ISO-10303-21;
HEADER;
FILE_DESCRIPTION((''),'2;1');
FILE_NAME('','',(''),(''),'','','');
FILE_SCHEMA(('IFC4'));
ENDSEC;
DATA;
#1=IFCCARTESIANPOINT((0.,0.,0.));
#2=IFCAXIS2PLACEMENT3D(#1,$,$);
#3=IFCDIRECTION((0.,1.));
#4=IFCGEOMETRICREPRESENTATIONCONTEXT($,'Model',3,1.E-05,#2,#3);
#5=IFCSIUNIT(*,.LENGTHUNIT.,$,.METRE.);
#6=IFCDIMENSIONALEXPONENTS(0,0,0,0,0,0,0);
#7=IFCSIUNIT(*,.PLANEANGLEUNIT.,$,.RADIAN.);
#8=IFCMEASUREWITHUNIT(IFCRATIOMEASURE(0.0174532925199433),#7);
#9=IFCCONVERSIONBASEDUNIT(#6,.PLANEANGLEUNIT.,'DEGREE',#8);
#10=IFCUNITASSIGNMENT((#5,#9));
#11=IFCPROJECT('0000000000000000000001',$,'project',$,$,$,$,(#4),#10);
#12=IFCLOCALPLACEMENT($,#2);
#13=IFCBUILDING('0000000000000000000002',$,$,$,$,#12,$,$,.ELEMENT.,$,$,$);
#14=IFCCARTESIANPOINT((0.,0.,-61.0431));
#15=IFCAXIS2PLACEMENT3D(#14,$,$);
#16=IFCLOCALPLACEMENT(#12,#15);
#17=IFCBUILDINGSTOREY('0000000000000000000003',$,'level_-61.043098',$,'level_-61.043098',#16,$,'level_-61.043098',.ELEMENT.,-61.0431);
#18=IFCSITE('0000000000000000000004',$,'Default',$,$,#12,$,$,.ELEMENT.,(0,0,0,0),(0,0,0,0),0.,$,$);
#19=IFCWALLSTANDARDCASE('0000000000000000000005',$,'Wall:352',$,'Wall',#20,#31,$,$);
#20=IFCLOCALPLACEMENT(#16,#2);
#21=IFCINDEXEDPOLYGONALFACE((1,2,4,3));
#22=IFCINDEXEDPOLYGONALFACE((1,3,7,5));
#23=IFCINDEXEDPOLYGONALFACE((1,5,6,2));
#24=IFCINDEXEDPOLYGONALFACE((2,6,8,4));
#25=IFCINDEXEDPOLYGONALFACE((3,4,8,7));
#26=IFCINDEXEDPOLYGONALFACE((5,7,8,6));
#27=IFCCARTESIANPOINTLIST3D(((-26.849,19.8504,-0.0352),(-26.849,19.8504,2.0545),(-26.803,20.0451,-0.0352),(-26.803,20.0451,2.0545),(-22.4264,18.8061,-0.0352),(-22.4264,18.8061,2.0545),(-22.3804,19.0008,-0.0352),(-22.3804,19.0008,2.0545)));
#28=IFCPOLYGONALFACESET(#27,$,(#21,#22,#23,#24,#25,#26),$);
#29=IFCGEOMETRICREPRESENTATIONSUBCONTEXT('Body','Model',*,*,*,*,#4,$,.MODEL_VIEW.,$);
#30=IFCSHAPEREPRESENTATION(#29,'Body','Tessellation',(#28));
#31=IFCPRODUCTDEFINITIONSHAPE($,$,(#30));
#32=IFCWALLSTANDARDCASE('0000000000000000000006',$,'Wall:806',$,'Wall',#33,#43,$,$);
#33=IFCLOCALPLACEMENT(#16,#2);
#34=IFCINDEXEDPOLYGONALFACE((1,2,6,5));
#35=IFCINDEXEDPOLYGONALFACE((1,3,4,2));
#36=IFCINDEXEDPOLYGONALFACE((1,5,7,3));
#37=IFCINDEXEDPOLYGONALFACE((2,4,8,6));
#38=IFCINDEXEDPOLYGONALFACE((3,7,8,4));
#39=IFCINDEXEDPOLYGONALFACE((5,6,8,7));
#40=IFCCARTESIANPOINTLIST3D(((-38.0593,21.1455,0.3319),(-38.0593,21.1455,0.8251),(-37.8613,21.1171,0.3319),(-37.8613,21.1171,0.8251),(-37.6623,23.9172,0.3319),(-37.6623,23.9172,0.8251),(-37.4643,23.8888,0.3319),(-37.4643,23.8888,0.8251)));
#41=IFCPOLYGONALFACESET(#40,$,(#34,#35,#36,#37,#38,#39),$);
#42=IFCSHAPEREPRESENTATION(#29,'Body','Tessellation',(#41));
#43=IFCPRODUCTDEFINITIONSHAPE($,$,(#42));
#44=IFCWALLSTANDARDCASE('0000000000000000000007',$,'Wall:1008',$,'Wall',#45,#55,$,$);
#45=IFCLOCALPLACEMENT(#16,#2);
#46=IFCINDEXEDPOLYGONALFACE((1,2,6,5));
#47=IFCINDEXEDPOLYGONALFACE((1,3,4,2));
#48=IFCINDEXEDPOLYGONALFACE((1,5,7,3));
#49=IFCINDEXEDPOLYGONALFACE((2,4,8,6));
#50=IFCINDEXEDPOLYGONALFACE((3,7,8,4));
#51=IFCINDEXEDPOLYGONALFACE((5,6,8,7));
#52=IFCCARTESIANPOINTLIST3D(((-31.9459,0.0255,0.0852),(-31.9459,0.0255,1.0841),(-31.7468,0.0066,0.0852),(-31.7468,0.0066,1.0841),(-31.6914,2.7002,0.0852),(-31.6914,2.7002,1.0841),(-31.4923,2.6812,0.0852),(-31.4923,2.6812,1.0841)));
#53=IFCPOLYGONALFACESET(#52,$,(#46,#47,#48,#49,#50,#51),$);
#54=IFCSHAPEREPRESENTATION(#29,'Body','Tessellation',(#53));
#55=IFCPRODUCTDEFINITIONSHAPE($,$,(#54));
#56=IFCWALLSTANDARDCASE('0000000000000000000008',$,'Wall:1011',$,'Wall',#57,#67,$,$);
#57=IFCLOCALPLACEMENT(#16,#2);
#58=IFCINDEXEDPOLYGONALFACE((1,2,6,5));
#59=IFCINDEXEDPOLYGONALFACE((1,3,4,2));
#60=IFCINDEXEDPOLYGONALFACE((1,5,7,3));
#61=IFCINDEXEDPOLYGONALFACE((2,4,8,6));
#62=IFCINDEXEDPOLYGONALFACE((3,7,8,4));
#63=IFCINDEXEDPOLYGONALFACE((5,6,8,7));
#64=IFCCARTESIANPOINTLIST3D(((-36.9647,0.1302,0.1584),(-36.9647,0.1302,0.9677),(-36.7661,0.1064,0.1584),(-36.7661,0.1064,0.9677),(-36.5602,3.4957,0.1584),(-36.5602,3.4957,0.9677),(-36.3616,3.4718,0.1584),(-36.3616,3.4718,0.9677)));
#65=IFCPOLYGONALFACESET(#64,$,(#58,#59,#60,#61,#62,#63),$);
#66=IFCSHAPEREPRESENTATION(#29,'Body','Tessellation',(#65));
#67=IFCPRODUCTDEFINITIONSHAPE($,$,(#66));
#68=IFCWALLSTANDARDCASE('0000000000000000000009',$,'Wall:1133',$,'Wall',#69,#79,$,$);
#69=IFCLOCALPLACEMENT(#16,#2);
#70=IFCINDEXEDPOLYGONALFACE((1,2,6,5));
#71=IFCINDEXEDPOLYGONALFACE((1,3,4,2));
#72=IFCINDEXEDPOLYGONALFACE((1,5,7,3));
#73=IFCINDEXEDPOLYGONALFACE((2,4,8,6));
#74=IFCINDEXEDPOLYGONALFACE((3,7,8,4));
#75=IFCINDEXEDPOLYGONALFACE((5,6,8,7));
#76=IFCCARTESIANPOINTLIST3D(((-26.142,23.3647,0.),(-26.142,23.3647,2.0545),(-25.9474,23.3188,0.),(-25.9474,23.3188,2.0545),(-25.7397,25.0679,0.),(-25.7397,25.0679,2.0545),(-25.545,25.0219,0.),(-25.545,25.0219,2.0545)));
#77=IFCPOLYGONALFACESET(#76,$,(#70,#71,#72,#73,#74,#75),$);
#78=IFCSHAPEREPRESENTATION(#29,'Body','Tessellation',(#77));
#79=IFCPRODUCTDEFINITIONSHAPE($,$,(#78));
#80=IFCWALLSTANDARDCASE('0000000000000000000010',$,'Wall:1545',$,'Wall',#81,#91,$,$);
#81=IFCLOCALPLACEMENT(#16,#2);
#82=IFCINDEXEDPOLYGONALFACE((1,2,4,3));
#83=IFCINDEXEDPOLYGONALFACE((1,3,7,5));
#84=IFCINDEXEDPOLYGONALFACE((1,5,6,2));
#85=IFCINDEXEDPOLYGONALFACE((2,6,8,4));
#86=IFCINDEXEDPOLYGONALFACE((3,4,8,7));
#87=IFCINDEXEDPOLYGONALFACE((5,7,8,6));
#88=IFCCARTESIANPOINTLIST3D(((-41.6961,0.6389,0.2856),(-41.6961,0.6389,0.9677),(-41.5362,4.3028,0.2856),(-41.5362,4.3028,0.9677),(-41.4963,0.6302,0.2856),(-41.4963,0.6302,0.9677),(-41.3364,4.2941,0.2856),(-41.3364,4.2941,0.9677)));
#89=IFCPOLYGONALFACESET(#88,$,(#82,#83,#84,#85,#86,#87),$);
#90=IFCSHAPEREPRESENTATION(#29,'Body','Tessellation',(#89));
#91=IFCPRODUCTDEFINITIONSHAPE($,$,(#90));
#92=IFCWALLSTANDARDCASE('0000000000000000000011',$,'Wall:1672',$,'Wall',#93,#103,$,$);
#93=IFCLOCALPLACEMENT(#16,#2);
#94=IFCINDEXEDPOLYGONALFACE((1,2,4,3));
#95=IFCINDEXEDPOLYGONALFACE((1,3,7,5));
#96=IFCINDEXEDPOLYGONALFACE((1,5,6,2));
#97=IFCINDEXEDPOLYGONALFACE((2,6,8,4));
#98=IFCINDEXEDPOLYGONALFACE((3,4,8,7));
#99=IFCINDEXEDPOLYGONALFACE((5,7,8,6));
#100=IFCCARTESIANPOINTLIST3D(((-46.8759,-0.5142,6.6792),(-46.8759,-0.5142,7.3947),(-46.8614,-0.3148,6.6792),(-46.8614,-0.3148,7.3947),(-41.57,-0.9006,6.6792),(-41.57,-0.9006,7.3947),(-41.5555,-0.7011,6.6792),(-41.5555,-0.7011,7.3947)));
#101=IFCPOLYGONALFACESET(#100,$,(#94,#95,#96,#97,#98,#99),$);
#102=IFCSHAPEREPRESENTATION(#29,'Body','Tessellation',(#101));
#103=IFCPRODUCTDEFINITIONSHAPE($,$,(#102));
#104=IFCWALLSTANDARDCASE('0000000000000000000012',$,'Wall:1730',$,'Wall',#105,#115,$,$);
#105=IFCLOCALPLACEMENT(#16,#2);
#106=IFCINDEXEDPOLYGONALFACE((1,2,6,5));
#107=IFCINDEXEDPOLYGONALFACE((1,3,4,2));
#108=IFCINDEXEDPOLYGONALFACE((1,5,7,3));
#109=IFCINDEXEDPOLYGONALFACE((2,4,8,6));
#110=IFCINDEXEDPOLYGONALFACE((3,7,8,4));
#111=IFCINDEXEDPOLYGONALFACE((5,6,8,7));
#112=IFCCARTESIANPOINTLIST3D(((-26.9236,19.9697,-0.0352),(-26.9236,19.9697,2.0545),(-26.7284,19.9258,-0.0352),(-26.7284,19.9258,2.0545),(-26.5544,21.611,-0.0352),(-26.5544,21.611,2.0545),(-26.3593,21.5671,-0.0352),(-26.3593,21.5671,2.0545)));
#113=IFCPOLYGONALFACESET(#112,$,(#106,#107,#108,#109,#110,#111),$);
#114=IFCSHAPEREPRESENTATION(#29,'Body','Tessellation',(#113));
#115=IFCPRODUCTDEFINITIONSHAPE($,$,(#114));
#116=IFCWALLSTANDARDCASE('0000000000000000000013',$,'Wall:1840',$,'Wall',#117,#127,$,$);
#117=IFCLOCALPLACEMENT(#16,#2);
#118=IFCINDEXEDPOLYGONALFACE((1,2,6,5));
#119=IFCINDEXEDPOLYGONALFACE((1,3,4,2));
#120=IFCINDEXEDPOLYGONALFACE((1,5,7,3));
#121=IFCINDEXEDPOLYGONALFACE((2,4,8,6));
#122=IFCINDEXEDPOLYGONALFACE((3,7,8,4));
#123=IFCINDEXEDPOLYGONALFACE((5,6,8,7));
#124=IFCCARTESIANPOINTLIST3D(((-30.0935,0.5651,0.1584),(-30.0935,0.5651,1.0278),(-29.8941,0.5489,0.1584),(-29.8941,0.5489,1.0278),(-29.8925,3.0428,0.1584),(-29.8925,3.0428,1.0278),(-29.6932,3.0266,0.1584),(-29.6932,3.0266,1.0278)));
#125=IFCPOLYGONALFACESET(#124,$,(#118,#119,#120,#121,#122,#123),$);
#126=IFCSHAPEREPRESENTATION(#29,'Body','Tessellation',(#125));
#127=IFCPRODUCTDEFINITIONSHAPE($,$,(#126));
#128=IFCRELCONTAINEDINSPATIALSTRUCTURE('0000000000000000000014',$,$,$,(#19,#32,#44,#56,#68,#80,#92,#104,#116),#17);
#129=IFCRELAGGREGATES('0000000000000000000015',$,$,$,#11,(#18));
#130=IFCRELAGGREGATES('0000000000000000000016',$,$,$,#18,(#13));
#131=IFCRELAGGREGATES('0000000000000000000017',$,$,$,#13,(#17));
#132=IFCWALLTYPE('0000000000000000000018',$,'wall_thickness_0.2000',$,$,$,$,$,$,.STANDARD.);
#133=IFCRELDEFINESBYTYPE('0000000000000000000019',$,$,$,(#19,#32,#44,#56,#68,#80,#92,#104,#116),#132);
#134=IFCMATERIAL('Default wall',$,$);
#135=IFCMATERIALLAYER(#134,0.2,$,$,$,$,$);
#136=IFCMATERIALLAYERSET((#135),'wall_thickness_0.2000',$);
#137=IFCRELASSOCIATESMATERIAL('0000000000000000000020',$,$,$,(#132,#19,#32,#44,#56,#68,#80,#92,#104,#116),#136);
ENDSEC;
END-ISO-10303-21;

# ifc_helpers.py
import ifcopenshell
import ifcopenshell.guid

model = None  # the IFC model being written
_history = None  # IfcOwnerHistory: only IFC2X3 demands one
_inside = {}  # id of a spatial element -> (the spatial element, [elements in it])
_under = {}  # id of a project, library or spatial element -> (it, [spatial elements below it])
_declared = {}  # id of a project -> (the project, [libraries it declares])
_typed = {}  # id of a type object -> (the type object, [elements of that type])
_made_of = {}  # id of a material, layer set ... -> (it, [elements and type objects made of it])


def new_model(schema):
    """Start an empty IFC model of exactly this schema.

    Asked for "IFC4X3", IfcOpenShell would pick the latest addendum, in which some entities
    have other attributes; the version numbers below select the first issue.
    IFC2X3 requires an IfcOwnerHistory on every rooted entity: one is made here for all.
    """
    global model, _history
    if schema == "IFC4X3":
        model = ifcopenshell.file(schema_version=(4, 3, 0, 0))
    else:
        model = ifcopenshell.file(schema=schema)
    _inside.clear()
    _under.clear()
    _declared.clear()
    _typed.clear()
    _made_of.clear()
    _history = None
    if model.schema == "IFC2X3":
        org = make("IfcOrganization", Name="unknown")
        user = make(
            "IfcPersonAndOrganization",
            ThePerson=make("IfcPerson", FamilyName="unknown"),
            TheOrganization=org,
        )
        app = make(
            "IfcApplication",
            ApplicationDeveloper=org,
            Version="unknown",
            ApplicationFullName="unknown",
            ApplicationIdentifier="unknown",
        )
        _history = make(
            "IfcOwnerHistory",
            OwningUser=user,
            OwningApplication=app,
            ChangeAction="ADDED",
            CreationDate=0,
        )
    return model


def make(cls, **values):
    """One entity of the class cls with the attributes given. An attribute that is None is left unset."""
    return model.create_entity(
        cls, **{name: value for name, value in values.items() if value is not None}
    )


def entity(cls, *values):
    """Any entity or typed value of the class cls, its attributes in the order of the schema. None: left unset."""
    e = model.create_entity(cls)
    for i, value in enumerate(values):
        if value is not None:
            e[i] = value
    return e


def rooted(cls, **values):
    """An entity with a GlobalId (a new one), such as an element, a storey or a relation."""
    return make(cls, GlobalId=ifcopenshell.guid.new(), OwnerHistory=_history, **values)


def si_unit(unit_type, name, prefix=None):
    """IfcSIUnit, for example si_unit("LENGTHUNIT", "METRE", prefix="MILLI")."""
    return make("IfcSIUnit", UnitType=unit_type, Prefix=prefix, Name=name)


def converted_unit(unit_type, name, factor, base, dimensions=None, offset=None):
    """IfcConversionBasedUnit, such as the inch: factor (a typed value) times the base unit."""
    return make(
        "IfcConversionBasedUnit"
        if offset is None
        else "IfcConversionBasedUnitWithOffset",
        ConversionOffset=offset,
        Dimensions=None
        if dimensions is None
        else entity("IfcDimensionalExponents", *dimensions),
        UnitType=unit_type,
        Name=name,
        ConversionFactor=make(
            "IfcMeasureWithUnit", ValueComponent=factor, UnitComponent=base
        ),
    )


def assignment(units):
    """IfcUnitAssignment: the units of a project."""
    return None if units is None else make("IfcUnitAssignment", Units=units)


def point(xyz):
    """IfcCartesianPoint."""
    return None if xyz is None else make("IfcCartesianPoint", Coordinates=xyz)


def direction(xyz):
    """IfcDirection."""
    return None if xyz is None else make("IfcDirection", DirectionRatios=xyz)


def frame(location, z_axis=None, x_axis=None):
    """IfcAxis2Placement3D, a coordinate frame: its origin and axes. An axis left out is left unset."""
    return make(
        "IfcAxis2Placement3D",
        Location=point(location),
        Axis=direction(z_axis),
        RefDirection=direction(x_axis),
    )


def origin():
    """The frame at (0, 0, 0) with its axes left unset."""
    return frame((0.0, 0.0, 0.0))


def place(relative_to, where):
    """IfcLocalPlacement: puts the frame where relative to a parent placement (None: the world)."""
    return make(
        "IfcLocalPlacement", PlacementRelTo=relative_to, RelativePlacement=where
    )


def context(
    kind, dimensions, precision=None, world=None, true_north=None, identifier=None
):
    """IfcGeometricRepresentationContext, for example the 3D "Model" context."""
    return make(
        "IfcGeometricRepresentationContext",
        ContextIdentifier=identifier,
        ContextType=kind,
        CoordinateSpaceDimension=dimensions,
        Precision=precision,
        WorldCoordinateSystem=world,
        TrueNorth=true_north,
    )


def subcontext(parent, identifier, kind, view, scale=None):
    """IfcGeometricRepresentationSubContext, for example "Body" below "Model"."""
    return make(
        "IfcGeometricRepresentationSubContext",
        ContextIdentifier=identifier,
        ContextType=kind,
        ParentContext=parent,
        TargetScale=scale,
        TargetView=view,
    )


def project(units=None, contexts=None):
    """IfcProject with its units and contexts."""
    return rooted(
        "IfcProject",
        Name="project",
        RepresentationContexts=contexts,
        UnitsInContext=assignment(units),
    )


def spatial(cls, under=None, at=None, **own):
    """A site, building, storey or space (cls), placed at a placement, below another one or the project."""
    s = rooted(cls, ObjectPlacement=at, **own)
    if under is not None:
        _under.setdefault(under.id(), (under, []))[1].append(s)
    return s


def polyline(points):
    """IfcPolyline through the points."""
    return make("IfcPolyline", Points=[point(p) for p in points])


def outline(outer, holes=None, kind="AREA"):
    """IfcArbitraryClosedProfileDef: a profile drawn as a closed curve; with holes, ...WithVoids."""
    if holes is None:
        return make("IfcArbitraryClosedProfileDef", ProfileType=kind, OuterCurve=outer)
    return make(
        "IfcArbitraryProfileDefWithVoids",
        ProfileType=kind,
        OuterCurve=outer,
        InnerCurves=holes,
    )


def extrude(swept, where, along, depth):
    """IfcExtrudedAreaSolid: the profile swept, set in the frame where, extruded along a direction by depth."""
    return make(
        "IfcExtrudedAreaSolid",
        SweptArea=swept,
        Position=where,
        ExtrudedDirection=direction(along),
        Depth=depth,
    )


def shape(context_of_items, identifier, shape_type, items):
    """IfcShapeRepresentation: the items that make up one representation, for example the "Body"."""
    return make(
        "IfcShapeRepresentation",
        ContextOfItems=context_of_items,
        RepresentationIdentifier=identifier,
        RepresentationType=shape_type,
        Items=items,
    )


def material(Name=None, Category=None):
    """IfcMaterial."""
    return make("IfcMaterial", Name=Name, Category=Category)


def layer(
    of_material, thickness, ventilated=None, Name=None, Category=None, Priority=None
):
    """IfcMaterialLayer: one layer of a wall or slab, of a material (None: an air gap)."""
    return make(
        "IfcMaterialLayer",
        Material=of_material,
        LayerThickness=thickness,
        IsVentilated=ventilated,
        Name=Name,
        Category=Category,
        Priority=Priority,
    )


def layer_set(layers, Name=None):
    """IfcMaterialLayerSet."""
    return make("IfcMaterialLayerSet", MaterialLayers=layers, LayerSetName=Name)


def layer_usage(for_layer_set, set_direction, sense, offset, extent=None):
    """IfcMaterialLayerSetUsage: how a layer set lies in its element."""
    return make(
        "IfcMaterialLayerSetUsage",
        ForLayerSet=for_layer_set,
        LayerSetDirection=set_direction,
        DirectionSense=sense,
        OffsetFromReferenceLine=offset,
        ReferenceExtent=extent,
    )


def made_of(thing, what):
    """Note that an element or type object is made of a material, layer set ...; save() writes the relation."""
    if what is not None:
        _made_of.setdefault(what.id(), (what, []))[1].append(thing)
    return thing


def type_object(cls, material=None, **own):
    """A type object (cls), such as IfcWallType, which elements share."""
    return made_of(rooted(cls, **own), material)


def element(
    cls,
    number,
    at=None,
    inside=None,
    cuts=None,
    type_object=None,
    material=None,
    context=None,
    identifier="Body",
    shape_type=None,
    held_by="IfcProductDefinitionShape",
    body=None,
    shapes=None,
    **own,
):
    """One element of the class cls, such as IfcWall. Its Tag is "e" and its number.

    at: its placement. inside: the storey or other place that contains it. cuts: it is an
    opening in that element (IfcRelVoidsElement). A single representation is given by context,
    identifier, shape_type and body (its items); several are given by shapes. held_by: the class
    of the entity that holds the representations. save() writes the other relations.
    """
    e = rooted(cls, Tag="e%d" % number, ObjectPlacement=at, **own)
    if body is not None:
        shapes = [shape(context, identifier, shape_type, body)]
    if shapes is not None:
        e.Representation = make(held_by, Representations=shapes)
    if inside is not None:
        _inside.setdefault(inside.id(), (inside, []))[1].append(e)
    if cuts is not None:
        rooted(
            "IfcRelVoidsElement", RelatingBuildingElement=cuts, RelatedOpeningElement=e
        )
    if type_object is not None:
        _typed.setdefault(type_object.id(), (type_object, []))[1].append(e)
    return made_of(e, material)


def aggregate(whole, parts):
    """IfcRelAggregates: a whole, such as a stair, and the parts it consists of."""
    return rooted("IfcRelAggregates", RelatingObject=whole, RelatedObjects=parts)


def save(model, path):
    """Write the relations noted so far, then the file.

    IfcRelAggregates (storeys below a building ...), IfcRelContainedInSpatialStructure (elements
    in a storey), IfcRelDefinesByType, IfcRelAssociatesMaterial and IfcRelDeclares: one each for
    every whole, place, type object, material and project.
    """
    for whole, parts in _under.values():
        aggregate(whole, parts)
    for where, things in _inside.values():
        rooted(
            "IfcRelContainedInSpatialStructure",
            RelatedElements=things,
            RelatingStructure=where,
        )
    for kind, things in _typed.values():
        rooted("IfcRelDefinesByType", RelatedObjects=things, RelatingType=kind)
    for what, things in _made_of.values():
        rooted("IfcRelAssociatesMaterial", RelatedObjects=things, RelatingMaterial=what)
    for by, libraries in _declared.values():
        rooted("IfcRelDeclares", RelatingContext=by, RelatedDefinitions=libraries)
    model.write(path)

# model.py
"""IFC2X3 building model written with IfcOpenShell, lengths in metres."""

from ifc_helpers import new_model, entity, si_unit, converted_unit, direction, frame, origin, place, context, subcontext, project, spatial, polyline, outline, extrude, material, layer, layer_set, layer_usage, type_object, element, save


model = new_model("IFC2X3")

# Units and contexts
model_context = context("Model", 3, precision=1e-05, world=origin(), true_north=direction((0.0, 1.0)))
body_context = subcontext(model_context, "Body", "Model", "MODEL_VIEW")
ifc_project = project(units=[si_unit("LENGTHUNIT", "METRE"), converted_unit("PLANEANGLEUNIT", "DEGREE", entity("IfcRatioMeasure", 0.0174532925199433), si_unit("PLANEANGLEUNIT", "RADIAN"), dimensions=[0, 0, 0, 0, 0, 0, 0])], contexts=[model_context])

# Site, building, storey
placement_1 = place(None, origin())
site = spatial("IfcSite", under=ifc_project, at=placement_1, Name="Default", CompositionType="ELEMENT", RefLatitude=(0, 0, 0, 0), RefLongitude=(0, 0, 0, 0), RefElevation=0.0)
building = spatial("IfcBuilding", under=site, at=placement_1, CompositionType="ELEMENT")
storey_placement = place(placement_1, frame((0.0, 0.0, -61.0431)))
storey = spatial("IfcBuildingStorey", under=building, at=storey_placement, Name="level_-61.043098", ObjectType="level_-61.043098", LongName="level_-61.043098", CompositionType="ELEMENT", Elevation=-61.0431)

# Walls
ifc_material = material(Name="Default wall")
ifc_layer = layer(ifc_material, 0.2)
ifc_layer_set = layer_set([ifc_layer], Name="wall_thickness_0.2000")
ifc_layer_usage = layer_usage(ifc_layer_set, "AXIS2", "POSITIVE", -0.1)
wall_type = type_object("IfcWallType", Name="wall_thickness_0.2000", PredefinedType="STANDARD", material=ifc_layer_set)
placement_2 = place(placement_1, frame((0.0, 0.0, -61.0783)))
wall_1_placement = place(placement_2, frame((-26.826, 19.9477, 0.0), z_axis=(0.0, 0.0, 1.0), x_axis=(0.973237, -0.229803, 0.0)))
element("IfcWallStandardCase", 1, at=wall_1_placement, inside=storey, type_object=wall_type, material=ifc_layer_usage, Name="Wall:352", ObjectType="Wall", context=body_context, shape_type="SweptSolid", body=[
    extrude(outline(polyline([(4.5442, -0.1), (4.5442, 0.1), (0.0, 0.1), (0.0, -0.1), (4.5442, -0.1)])), origin(), (0.0, 0.0, 1.0), 2.0897),
])
placement_3 = place(placement_1, frame((0.0, 0.0, -60.7112)))
wall_2_placement = place(placement_3, frame((-37.9603, 21.1313, 0.0), z_axis=(0.0, 0.0, 1.0), x_axis=(0.14177, 0.9899, 0.0)))
element("IfcWallStandardCase", 2, at=wall_2_placement, inside=storey, type_object=wall_type, material=ifc_layer_usage, Name="Wall:806", ObjectType="Wall", context=body_context, shape_type="SweptSolid", body=[
    extrude(outline(polyline([(2.8, -0.1), (2.8, 0.1), (0.0, 0.1), (0.0, -0.1), (2.8, -0.1)])), origin(), (0.0, 0.0, 1.0), 0.4932),
])
placement_4 = place(placement_1, frame((0.0, 0.0, -60.9579)))
wall_3_placement = place(placement_4, frame((-31.8464, 0.016, 0.0), z_axis=(0.0, 0.0, 1.0), x_axis=(0.094731, 0.995503, 0.0)))
element("IfcWallStandardCase", 3, at=wall_3_placement, inside=storey, type_object=wall_type, material=ifc_layer_usage, Name="Wall:1008", ObjectType="Wall", context=body_context, shape_type="SweptSolid", body=[
    extrude(outline(polyline([(2.6867, -0.1), (2.6867, 0.1), (0.0, 0.1), (0.0, -0.1), (2.6867, -0.1)])), origin(), (0.0, 0.0, 1.0), 0.9989),
])
placement_5 = place(placement_1, frame((0.0, 0.0, -60.8847)))
wall_4_placement = place(placement_5, frame((-36.8654, 0.1183, 0.0), z_axis=(0.0, 0.0, 1.0), x_axis=(0.119331, 0.992854, 0.0)))
element("IfcWallStandardCase", 4, at=wall_4_placement, inside=storey, type_object=wall_type, material=ifc_layer_usage, Name="Wall:1011", ObjectType="Wall", context=body_context, shape_type="SweptSolid", body=[
    extrude(outline(polyline([(3.3897, -0.1), (3.3897, 0.1), (0.0, 0.1), (0.0, -0.1), (3.3897, -0.1)])), origin(), (0.0, 0.0, 1.0), 0.8093),
])
wall_5_placement = place(storey_placement, frame((-25.6423, 25.0449, 0.0), z_axis=(0.0, 0.0, 1.0), x_axis=(-0.229919, -0.97321, 0.0)))
element("IfcWallStandardCase", 5, at=wall_5_placement, inside=storey, type_object=wall_type, material=ifc_layer_usage, Name="Wall:1133", ObjectType="Wall", context=body_context, shape_type="SweptSolid", body=[
    extrude(outline(polyline([(1.75, -0.1), (1.75, 0.1), (0.0, 0.1), (0.0, -0.1), (1.75, -0.1)])), origin(), (0.0, 0.0, 1.0), 2.0545),
])
placement_6 = place(placement_1, frame((0.0, 0.0, -60.7575)))
wall_6_placement = place(placement_6, frame((-41.5962, 0.6346, 0.0), z_axis=(0.0, 0.0, 1.0), x_axis=(0.043602, 0.999049, 0.0)))
element("IfcWallStandardCase", 6, at=wall_6_placement, inside=storey, type_object=wall_type, material=ifc_layer_usage, Name="Wall:1545", ObjectType="Wall", context=body_context, shape_type="SweptSolid", body=[
    extrude(outline(polyline([(3.6674, -0.1), (3.6674, 0.1), (0.0, 0.1), (0.0, -0.1), (3.6674, -0.1)])), origin(), (0.0, 0.0, 1.0), 0.6821),
])
placement_7 = place(placement_1, frame((0.0, 0.0, -54.3639)))
wall_7_placement = place(placement_7, frame((-46.8687, -0.4145, 0.0), z_axis=(0.0, 0.0, 1.0), x_axis=(0.99736, -0.072617, 0.0)))
element("IfcWallStandardCase", 7, at=wall_7_placement, inside=storey, type_object=wall_type, material=ifc_layer_usage, Name="Wall:1672", ObjectType="Wall", context=body_context, shape_type="SweptSolid", body=[
    extrude(outline(polyline([(5.32, -0.1), (5.32, 0.1), (0.0, 0.1), (0.0, -0.1), (5.32, -0.1)])), origin(), (0.0, 0.0, 1.0), 0.7155),
])
placement_8 = place(placement_1, frame((0.0, 0.0, -61.0783)))
wall_8_placement = place(placement_8, frame((-26.4568, 21.5891, 0.0), z_axis=(0.0, 0.0, 1.0), x_axis=(-0.21944, -0.975626, 0.0)))
element("IfcWallStandardCase", 8, at=wall_8_placement, inside=storey, type_object=wall_type, material=ifc_layer_usage, Name="Wall:1730", ObjectType="Wall", context=body_context, shape_type="SweptSolid", body=[
    extrude(outline(polyline([(1.6823, -0.1), (1.6823, 0.1), (0.0, 0.1), (0.0, -0.1), (1.6823, -0.1)])), origin(), (0.0, 0.0, 1.0), 2.0897),
])
placement_9 = place(placement_1, frame((0.0, 0.0, -60.8847)))
wall_9_placement = place(placement_9, frame((-29.7928, 3.0347, 0.0), z_axis=(0.0, 0.0, 1.0), x_axis=(-0.080837, -0.996727, 0.0)))
element("IfcWallStandardCase", 9, at=wall_9_placement, inside=storey, type_object=wall_type, material=ifc_layer_usage, Name="Wall:1840", ObjectType="Wall", context=body_context, shape_type="SweptSolid", body=[
    extrude(outline(polyline([(2.4859, -0.1), (2.4859, 0.1), (0.0, 0.1), (0.0, -0.1), (2.4859, -0.1)])), origin(), (0.0, 0.0, 1.0), 0.8695),
])

save(model, "model.ifc")
